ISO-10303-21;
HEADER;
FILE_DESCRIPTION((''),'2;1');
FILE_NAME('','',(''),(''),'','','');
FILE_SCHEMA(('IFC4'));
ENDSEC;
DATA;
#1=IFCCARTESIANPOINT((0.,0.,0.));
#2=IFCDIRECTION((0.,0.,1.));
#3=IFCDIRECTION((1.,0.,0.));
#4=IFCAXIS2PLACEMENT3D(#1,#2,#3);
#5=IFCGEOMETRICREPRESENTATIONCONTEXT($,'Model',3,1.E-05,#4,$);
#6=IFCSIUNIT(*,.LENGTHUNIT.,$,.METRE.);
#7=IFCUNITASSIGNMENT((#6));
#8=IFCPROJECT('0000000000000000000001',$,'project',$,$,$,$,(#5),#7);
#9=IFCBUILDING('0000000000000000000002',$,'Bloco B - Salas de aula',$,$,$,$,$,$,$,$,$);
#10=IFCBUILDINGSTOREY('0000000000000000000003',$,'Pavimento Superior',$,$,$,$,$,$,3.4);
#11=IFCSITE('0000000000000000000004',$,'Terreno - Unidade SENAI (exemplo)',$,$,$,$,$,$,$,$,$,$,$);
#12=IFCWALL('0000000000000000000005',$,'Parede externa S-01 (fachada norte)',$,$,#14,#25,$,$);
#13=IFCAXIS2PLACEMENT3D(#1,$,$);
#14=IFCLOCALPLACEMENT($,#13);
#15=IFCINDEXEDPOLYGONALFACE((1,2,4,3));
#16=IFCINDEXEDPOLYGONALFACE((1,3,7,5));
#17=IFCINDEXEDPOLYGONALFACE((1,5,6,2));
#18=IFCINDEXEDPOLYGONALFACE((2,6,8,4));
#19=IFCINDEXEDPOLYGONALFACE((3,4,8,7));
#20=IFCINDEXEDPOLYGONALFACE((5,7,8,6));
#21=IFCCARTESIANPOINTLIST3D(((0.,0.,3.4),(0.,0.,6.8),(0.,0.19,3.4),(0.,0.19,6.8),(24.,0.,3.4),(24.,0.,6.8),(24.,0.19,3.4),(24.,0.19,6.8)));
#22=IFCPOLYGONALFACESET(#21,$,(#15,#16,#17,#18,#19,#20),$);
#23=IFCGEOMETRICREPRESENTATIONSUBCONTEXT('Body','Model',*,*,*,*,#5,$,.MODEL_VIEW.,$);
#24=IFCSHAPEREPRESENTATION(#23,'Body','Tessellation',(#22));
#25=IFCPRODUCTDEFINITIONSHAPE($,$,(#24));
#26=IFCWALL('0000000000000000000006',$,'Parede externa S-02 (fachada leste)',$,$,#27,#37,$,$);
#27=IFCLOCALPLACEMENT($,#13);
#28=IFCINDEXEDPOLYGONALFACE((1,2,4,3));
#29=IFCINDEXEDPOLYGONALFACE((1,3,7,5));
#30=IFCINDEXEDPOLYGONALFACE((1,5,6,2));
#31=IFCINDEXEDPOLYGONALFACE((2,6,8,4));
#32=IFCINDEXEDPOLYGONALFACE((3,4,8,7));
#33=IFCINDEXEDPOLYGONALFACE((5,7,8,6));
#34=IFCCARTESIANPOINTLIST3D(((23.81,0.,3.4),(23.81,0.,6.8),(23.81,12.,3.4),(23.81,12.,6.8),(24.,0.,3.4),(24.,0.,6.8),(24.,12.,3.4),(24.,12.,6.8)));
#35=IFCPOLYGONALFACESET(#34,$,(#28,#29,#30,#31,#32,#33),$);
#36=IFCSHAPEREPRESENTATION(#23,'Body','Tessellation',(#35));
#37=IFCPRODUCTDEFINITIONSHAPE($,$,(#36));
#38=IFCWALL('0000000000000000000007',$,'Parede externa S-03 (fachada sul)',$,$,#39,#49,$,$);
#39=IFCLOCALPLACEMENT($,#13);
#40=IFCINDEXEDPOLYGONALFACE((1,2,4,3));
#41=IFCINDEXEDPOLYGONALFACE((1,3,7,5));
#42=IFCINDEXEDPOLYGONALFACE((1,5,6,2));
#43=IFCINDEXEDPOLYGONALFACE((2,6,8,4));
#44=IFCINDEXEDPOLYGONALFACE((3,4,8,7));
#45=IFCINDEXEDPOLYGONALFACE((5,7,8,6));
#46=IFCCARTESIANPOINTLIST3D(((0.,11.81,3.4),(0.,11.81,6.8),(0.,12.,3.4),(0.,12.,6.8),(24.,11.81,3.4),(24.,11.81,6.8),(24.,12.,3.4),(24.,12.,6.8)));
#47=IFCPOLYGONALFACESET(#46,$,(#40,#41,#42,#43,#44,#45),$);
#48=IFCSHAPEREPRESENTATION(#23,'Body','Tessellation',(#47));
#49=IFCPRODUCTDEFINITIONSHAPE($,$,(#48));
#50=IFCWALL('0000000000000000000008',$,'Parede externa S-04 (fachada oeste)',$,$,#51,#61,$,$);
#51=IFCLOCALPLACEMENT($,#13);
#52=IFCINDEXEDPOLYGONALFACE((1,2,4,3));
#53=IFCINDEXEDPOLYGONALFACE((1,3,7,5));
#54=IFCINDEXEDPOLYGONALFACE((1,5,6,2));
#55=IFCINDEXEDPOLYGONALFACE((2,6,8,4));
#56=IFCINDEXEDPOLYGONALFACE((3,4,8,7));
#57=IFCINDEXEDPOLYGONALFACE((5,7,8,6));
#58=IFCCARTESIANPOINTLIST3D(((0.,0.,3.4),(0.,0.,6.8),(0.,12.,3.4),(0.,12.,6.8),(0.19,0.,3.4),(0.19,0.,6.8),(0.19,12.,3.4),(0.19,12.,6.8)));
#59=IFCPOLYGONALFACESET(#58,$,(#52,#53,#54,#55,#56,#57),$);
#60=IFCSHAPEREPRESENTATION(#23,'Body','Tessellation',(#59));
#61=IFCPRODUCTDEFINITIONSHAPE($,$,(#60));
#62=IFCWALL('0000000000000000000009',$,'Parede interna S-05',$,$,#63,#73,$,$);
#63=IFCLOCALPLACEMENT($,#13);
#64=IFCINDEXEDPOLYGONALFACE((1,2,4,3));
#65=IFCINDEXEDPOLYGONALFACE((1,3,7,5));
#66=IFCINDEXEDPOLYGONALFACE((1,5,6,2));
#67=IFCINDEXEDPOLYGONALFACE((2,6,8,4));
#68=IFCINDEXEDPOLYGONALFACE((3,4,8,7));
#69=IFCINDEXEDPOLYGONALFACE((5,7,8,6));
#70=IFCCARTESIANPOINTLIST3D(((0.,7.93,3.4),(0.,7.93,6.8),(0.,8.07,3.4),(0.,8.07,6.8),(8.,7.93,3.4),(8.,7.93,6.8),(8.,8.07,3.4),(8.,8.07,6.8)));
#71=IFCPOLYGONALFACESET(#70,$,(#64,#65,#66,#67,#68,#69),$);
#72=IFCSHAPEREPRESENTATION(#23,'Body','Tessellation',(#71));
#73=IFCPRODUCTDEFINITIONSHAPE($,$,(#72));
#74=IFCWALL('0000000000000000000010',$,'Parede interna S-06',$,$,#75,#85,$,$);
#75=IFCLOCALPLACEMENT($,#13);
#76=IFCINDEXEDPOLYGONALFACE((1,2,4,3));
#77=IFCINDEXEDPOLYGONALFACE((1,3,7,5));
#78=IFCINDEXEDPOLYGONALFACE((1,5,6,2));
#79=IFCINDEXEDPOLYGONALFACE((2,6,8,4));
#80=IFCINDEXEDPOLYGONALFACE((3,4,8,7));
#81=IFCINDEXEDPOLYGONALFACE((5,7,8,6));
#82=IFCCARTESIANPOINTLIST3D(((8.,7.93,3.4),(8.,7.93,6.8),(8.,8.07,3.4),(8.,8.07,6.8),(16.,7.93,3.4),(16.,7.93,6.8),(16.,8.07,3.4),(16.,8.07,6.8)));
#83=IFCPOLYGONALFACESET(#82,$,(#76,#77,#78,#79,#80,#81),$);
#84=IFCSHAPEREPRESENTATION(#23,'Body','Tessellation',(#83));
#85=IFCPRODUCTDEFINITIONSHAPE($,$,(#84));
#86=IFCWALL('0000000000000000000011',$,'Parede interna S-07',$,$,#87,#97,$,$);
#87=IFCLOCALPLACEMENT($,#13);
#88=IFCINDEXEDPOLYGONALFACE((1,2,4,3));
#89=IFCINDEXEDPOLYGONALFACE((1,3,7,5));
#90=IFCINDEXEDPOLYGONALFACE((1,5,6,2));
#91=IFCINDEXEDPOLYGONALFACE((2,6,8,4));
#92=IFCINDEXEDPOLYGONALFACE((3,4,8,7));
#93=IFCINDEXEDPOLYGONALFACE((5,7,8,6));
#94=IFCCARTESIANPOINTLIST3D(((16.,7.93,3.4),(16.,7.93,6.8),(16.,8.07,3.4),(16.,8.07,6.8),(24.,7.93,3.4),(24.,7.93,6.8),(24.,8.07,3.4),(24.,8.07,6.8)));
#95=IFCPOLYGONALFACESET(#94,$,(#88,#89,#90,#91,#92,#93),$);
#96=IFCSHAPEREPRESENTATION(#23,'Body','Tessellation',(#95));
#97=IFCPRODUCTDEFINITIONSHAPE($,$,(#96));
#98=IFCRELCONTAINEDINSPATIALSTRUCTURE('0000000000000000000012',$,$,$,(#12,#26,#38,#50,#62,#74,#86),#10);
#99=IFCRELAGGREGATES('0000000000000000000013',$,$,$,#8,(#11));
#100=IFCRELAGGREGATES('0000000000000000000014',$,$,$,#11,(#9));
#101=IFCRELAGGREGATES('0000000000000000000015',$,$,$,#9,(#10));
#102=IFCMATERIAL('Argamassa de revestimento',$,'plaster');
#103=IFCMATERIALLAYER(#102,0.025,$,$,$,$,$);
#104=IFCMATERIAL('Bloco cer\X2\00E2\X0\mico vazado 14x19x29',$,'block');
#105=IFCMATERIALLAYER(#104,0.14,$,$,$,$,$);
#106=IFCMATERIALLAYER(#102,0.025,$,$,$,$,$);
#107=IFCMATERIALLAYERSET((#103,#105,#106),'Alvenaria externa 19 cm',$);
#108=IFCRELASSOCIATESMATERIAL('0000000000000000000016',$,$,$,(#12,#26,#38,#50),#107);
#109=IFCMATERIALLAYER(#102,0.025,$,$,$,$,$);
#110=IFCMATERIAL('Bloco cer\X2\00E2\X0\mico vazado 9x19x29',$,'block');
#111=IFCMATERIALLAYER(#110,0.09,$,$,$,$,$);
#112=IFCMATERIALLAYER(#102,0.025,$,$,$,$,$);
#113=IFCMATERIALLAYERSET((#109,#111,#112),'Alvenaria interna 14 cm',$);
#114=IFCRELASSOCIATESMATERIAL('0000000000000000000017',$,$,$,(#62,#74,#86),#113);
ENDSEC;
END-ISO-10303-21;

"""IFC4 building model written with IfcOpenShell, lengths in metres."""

from ifc_helpers import new_model, si_unit, frame, origin_with_axes, place, context, subcontext, project, spatial, indexed_curve, outline, extrude, material, layer, layer_set, layer_usage, element, save


model = new_model("IFC4")

# Units and contexts
model_context = context("Model", 3, precision=1e-05, world=origin_with_axes())
body_context = subcontext(model_context, "Body", "Model", "MODEL_VIEW")
ifc_project = project(units=[si_unit("LENGTHUNIT", "METRE")], contexts=[model_context])

# Site, building, storey
site = spatial("IfcSite", under=ifc_project, Name="Terreno - Unidade SENAI (exemplo)")
building = spatial("IfcBuilding", under=site, Name="Bloco B - Salas de aula")
storey = spatial("IfcBuildingStorey", under=building, Name="Pavimento Superior", Elevation=3.4)

# Walls
ifc_material_1 = material(Name="Argamassa de revestimento", Category="plaster")
ifc_layer_1 = layer(ifc_material_1, 0.025)
ifc_material_2 = material(Name="Bloco cerâmico vazado 14x19x29", Category="block")
ifc_layer_2 = layer(ifc_material_2, 0.14)
ifc_layer_3 = layer(ifc_material_1, 0.025)
ifc_layer_set_1 = layer_set([ifc_layer_1, ifc_layer_2, ifc_layer_3], Name="Alvenaria externa 19 cm")
ifc_layer_usage_1 = layer_usage(ifc_layer_set_1, "AXIS2", "POSITIVE", 0.0)
wall_1_placement = place(None, frame((0.0, 0.0, 3.4), z_axis=(0.0, 0.0, 1.0), x_axis=(1.0, 0.0, 0.0)))
element("IfcWall", 1, at=wall_1_placement, inside=storey, material=ifc_layer_usage_1, Name="Parede externa S-01 (fachada norte)", context=body_context, shape_type="SweptSolid", body=[
    extrude(outline(indexed_curve([(0.0, 0.0), (0.0, 0.19), (24.0, 0.19), (24.0, 0.0), (0.0, 0.0)], self_intersect=False)), origin_with_axes(), (0.0, 0.0, 1.0), 3.4),
])
ifc_layer_usage_2 = layer_usage(ifc_layer_set_1, "AXIS2", "POSITIVE", 0.0)
wall_2_placement = place(None, frame((24.0, 0.0, 3.4), z_axis=(0.0, 0.0, 1.0), x_axis=(0.0, 1.0, 0.0)))
element("IfcWall", 2, at=wall_2_placement, inside=storey, material=ifc_layer_usage_2, Name="Parede externa S-02 (fachada leste)", context=body_context, shape_type="SweptSolid", body=[
    extrude(outline(indexed_curve([(0.0, 0.0), (0.0, 0.19), (12.0, 0.19), (12.0, 0.0), (0.0, 0.0)], self_intersect=False)), origin_with_axes(), (0.0, 0.0, 1.0), 3.4),
])
ifc_layer_usage_3 = layer_usage(ifc_layer_set_1, "AXIS2", "POSITIVE", 0.0)
wall_3_placement = place(None, frame((0.0, 11.81, 3.4), z_axis=(0.0, 0.0, 1.0), x_axis=(1.0, 0.0, 0.0)))
element("IfcWall", 3, at=wall_3_placement, inside=storey, material=ifc_layer_usage_3, Name="Parede externa S-03 (fachada sul)", context=body_context, shape_type="SweptSolid", body=[
    extrude(outline(indexed_curve([(0.0, 0.0), (0.0, 0.19), (24.0, 0.19), (24.0, 0.0), (0.0, 0.0)], self_intersect=False)), origin_with_axes(), (0.0, 0.0, 1.0), 3.4),
])
ifc_layer_usage_4 = layer_usage(ifc_layer_set_1, "AXIS2", "POSITIVE", 0.0)
wall_4_placement = place(None, frame((0.19, 0.0, 3.4), z_axis=(0.0, 0.0, 1.0), x_axis=(0.0, 1.0, 0.0)))
element("IfcWall", 4, at=wall_4_placement, inside=storey, material=ifc_layer_usage_4, Name="Parede externa S-04 (fachada oeste)", context=body_context, shape_type="SweptSolid", body=[
    extrude(outline(indexed_curve([(0.0, 0.0), (0.0, 0.19), (12.0, 0.19), (12.0, 0.0), (0.0, 0.0)], self_intersect=False)), origin_with_axes(), (0.0, 0.0, 1.0), 3.4),
])
ifc_layer_4 = layer(ifc_material_1, 0.025)
ifc_material_3 = material(Name="Bloco cerâmico vazado 9x19x29", Category="block")
ifc_layer_5 = layer(ifc_material_3, 0.09)
ifc_layer_6 = layer(ifc_material_1, 0.025)
ifc_layer_set_2 = layer_set([ifc_layer_4, ifc_layer_5, ifc_layer_6], Name="Alvenaria interna 14 cm")
ifc_layer_usage_5 = layer_usage(ifc_layer_set_2, "AXIS2", "POSITIVE", 0.0)
wall_5_placement = place(None, frame((0.0, 7.93, 3.4), z_axis=(0.0, 0.0, 1.0), x_axis=(1.0, 0.0, 0.0)))
element("IfcWall", 5, at=wall_5_placement, inside=storey, material=ifc_layer_usage_5, Name="Parede interna S-05", context=body_context, shape_type="SweptSolid", body=[
    extrude(outline(indexed_curve([(0.0, 0.0), (0.0, 0.14), (8.0, 0.14), (8.0, 0.0), (0.0, 0.0)], self_intersect=False)), origin_with_axes(), (0.0, 0.0, 1.0), 3.4),
])
ifc_layer_usage_6 = layer_usage(ifc_layer_set_2, "AXIS2", "POSITIVE", 0.0)
wall_6_placement = place(None, frame((8.0, 7.93, 3.4), z_axis=(0.0, 0.0, 1.0), x_axis=(1.0, 0.0, 0.0)))
element("IfcWall", 6, at=wall_6_placement, inside=storey, material=ifc_layer_usage_6, Name="Parede interna S-06", context=body_context, shape_type="SweptSolid", body=[
    extrude(outline(indexed_curve([(0.0, 0.0), (0.0, 0.14), (8.0, 0.14), (8.0, 0.0), (0.0, 0.0)], self_intersect=False)), origin_with_axes(), (0.0, 0.0, 1.0), 3.4),
])
ifc_layer_usage_7 = layer_usage(ifc_layer_set_2, "AXIS2", "POSITIVE", 0.0)
wall_7_placement = place(None, frame((16.0, 7.93, 3.4), z_axis=(0.0, 0.0, 1.0), x_axis=(1.0, 0.0, 0.0)))
element("IfcWall", 7, at=wall_7_placement, inside=storey, material=ifc_layer_usage_7, Name="Parede interna S-07", context=body_context, shape_type="SweptSolid", body=[
    extrude(outline(indexed_curve([(0.0, 0.0), (0.0, 0.14), (8.0, 0.14), (8.0, 0.0), (0.0, 0.0)], self_intersect=False)), origin_with_axes(), (0.0, 0.0, 1.0), 3.4),
])

save(model, "model.ifc")
